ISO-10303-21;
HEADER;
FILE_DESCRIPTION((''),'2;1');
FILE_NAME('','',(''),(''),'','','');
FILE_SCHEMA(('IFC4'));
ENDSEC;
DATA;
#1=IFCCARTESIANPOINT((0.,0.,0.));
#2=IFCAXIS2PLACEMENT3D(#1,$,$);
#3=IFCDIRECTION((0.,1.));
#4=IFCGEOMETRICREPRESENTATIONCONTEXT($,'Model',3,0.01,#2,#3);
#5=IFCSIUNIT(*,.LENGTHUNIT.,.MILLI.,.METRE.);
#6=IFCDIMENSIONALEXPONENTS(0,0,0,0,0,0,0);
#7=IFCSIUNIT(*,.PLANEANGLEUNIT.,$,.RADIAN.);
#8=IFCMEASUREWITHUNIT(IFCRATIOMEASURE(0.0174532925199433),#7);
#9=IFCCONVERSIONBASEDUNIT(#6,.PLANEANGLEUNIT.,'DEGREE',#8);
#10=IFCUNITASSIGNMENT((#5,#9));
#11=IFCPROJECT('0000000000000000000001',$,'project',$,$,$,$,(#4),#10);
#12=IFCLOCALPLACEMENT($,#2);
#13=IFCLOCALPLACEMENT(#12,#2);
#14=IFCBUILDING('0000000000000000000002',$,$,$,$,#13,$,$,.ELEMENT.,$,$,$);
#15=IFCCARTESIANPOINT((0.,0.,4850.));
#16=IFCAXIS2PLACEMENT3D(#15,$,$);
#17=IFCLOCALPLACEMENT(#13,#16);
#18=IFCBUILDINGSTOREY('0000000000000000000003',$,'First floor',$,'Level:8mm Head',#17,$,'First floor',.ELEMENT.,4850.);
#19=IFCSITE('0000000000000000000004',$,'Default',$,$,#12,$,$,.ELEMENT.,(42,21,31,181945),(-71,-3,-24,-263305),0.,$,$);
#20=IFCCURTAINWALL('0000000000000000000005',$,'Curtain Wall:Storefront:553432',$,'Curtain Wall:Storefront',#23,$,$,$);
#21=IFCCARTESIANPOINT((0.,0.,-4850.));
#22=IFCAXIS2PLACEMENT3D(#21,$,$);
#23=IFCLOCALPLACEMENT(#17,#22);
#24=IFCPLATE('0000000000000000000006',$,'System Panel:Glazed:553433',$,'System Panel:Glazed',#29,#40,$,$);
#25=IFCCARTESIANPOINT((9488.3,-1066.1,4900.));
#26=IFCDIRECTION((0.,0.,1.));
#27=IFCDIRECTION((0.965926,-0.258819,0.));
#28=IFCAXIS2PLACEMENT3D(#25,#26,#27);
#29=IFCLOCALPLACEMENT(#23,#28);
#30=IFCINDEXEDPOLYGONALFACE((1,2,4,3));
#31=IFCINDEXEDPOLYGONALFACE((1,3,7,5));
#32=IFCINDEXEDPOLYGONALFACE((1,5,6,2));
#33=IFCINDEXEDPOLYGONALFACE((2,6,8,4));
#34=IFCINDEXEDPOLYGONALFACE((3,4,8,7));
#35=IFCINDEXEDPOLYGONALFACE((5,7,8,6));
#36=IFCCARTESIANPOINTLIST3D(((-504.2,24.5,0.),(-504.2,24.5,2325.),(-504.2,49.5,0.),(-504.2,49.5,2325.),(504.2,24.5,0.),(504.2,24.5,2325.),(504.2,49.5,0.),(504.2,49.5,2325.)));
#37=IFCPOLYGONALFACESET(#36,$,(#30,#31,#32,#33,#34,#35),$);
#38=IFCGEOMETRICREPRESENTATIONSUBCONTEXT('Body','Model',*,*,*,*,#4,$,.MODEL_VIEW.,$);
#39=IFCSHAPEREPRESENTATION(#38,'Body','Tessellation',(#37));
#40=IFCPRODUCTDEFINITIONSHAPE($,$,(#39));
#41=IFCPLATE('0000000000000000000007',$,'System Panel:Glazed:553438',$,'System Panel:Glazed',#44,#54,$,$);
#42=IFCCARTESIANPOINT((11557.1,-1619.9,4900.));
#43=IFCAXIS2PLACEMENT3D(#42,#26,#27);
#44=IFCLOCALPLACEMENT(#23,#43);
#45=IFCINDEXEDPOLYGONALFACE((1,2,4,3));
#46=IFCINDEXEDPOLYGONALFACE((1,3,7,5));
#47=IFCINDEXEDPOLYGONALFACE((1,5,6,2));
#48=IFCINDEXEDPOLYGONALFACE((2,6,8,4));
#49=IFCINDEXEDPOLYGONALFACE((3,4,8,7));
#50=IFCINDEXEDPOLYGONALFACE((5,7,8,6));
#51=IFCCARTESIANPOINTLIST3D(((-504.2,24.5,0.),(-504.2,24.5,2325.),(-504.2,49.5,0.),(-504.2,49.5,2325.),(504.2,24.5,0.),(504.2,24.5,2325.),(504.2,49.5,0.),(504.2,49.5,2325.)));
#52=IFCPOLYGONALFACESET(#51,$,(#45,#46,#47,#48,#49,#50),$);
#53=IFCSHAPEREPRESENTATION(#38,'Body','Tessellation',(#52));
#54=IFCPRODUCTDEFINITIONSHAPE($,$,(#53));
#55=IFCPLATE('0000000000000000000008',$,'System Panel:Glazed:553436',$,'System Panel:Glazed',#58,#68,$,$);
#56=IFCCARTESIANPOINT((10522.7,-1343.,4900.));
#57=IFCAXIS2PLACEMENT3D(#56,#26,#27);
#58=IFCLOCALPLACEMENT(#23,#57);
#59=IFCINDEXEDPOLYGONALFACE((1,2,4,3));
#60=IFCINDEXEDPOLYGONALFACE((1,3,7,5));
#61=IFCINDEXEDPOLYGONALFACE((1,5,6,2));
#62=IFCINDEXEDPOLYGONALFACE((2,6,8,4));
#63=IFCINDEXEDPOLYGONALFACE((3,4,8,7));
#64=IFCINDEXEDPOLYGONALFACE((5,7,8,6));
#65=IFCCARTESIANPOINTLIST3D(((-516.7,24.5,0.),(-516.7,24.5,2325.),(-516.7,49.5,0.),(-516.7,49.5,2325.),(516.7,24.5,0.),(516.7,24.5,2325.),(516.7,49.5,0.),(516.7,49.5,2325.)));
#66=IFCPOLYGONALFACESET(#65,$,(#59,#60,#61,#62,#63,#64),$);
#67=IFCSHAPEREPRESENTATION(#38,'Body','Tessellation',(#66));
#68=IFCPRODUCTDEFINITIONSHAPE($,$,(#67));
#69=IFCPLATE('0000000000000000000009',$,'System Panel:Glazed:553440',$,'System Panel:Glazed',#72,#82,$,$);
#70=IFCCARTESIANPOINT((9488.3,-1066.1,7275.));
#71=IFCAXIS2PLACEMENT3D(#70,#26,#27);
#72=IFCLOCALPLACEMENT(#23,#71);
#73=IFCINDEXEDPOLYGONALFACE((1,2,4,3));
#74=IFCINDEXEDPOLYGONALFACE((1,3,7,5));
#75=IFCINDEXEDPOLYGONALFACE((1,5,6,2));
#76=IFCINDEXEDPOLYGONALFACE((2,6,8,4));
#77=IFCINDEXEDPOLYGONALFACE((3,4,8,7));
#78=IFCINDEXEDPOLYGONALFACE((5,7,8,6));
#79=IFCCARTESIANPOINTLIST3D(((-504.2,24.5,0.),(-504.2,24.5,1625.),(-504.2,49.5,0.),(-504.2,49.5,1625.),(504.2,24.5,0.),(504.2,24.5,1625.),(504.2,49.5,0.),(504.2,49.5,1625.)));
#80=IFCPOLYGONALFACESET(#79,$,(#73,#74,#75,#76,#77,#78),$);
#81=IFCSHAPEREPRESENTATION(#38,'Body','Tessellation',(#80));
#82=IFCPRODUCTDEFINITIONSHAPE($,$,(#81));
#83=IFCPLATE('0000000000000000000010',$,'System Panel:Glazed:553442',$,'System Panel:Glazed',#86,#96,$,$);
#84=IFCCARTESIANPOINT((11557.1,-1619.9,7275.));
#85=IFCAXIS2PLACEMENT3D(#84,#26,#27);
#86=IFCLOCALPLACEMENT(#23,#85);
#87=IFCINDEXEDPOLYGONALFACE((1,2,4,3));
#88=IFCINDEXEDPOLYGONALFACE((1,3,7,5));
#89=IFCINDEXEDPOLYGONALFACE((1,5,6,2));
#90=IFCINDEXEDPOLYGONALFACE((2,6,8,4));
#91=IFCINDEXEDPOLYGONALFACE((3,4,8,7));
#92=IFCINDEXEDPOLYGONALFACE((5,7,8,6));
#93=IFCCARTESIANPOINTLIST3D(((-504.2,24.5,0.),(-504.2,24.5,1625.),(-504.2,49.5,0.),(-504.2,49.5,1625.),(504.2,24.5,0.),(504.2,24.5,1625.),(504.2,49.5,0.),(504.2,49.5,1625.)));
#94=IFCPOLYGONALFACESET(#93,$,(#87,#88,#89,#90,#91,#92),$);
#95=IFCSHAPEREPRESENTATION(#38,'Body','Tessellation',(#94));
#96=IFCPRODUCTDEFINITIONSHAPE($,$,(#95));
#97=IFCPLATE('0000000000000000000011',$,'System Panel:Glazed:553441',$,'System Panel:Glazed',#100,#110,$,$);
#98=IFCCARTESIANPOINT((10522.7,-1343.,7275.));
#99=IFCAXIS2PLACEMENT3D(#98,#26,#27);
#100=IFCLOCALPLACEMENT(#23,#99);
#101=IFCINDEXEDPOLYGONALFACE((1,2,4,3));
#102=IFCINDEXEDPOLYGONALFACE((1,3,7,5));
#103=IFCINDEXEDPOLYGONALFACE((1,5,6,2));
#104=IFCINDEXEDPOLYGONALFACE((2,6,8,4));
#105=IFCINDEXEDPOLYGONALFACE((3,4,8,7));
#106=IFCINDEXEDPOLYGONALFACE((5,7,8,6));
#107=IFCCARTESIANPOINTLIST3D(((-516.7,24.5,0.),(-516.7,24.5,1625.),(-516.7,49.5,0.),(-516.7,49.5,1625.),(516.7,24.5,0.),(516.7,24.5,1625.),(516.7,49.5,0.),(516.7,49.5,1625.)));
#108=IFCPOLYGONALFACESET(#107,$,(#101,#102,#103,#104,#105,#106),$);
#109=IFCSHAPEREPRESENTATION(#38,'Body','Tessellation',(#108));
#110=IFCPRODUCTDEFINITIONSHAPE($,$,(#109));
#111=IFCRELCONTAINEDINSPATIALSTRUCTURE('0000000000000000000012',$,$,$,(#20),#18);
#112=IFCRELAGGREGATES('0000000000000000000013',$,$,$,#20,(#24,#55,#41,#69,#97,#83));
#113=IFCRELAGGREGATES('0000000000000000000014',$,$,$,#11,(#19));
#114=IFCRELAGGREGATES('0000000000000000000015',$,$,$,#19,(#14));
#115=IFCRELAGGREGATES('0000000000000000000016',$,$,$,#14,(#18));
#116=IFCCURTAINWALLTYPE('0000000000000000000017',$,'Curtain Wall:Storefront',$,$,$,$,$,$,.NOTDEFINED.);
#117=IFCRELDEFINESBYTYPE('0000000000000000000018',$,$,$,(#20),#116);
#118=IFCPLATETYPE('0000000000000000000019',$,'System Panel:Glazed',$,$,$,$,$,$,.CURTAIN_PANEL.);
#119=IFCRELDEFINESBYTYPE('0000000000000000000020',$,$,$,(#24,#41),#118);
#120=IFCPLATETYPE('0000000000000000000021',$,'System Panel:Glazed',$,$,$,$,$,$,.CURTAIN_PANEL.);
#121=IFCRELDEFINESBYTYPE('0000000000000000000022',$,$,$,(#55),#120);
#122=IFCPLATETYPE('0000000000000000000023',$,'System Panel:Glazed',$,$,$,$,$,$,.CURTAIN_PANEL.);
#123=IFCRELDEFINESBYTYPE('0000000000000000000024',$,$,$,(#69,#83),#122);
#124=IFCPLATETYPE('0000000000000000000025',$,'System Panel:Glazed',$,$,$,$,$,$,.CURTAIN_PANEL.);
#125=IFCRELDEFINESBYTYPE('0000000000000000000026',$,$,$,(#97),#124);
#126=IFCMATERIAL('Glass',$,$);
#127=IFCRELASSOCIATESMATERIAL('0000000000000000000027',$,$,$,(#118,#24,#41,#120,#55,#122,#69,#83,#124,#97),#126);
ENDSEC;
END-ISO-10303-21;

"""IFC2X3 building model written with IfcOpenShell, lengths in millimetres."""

from ifc_helpers import new_model, entity, si_unit, converted_unit, direction, frame, frame_2d, origin, place, context, subcontext, project, spatial, rectangle, extrude, source, transform, mapped, material, type_object, type_shapes, element, aggregate, save


model = new_model("IFC2X3")

# Units and contexts
model_context = context("Model", 3, precision=0.01, world=origin(), true_north=direction((0.0, 1.0)))
body_context = subcontext(model_context, "Body", "Model", "MODEL_VIEW")
ifc_project = project(units=[si_unit("LENGTHUNIT", "METRE", prefix="MILLI"), converted_unit("PLANEANGLEUNIT", "DEGREE", entity("IfcRatioMeasure", 0.0174532925199433), si_unit("PLANEANGLEUNIT", "RADIAN"), dimensions=[0, 0, 0, 0, 0, 0, 0])], contexts=[model_context])

# Site, building, storey
site_placement = place(None, origin())
site = spatial("IfcSite", under=ifc_project, at=site_placement, Name="Default", CompositionType="ELEMENT", RefLatitude=(42, 21, 31, 181945), RefLongitude=(-71, -3, -24, -263305), RefElevation=0.0)
building_placement = place(site_placement, origin())
building = spatial("IfcBuilding", under=site, at=building_placement, CompositionType="ELEMENT")
storey_placement = place(building_placement, frame((0.0, 0.0, 4850.0)))
storey = spatial("IfcBuildingStorey", under=building, at=storey_placement, Name="First floor", ObjectType="Level:8mm Head", LongName="First floor", CompositionType="ELEMENT", Elevation=4850.0)

# Curtain wall, plates
curtain_wall_type = type_object("IfcCurtainWallType", Name="Curtain Wall:Storefront", PredefinedType="NOTDEFINED")
curtain_wall_placement = place(storey_placement, frame((0.0, 0.0, -4850.0)))
curtain_wall = element("IfcCurtainWall", 1, at=curtain_wall_placement, inside=storey, type_object=curtain_wall_type, Name="Curtain Wall:Storefront:553432", ObjectType="Curtain Wall:Storefront")
ifc_material_1 = material(Name="Glass")
plate_type_1 = type_object("IfcPlateType", Name="System Panel:Glazed", PredefinedType="CURTAIN_PANEL", material=ifc_material_1)
shared_shape_1 = source(origin(), body_context, "Body", "SweptSolid", [
    extrude(rectangle(XDim=25.0, YDim=1008.3, at=frame_2d((0.0, 0.0), x_axis=(1.0, 0.0))), frame((0.0, 37.0, 0.0), z_axis=(0.0, 0.0, 1.0), x_axis=(0.0, 1.0, 0.0)), (0.0, 0.0, 1.0), 2325.0),
])
type_shapes(plate_type_1, [shared_shape_1])
plate_1_placement = place(curtain_wall_placement, frame((9488.3, -1066.1, 4900.0), z_axis=(0.0, 0.0, 1.0), x_axis=(0.965926, -0.258819, 0.0)))
plate_1 = element("IfcPlate", 2, at=plate_1_placement, type_object=plate_type_1, material=ifc_material_1, Name="System Panel:Glazed:553433", ObjectType="System Panel:Glazed", context=body_context, shape_type="MappedRepresentation", body=[
    mapped(shared_shape_1, transform((0.0, 0.0, 0.0), scale=1.0)),
])
plate_2_placement = place(curtain_wall_placement, frame((11557.1, -1619.9, 4900.0), z_axis=(0.0, 0.0, 1.0), x_axis=(0.965926, -0.258819, 0.0)))
plate_2 = element("IfcPlate", 3, at=plate_2_placement, type_object=plate_type_1, material=ifc_material_1, Name="System Panel:Glazed:553438", ObjectType="System Panel:Glazed", context=body_context, shape_type="MappedRepresentation", body=[
    mapped(shared_shape_1, transform((0.0, 0.0, 0.0), scale=1.0)),
])
plate_type_2 = type_object("IfcPlateType", Name="System Panel:Glazed", PredefinedType="CURTAIN_PANEL", material=ifc_material_1)
shared_shape_2 = source(origin(), body_context, "Body", "SweptSolid", [
    extrude(rectangle(XDim=25.0, YDim=1033.3, at=frame_2d((0.0, 0.0), x_axis=(1.0, 0.0))), frame((0.0, 37.0, 0.0), z_axis=(0.0, 0.0, 1.0), x_axis=(0.0, 1.0, 0.0)), (0.0, 0.0, 1.0), 2325.0),
])
type_shapes(plate_type_2, [shared_shape_2])
plate_3_placement = place(curtain_wall_placement, frame((10522.7, -1343.0, 4900.0), z_axis=(0.0, 0.0, 1.0), x_axis=(0.965926, -0.258819, 0.0)))
plate_3 = element("IfcPlate", 4, at=plate_3_placement, type_object=plate_type_2, material=ifc_material_1, Name="System Panel:Glazed:553436", ObjectType="System Panel:Glazed", context=body_context, shape_type="MappedRepresentation", body=[
    mapped(shared_shape_2, transform((0.0, 0.0, 0.0), scale=1.0)),
])
plate_type_3 = type_object("IfcPlateType", Name="System Panel:Glazed", PredefinedType="CURTAIN_PANEL", material=ifc_material_1)
shared_shape_3 = source(origin(), body_context, "Body", "SweptSolid", [
    extrude(rectangle(XDim=25.0, YDim=1008.3, at=frame_2d((0.0, 0.0), x_axis=(1.0, 0.0))), frame((0.0, 37.0, 0.0), z_axis=(0.0, 0.0, 1.0), x_axis=(0.0, 1.0, 0.0)), (0.0, 0.0, 1.0), 1625.0),
])
type_shapes(plate_type_3, [shared_shape_3])
plate_4_placement = place(curtain_wall_placement, frame((9488.3, -1066.1, 7275.0), z_axis=(0.0, 0.0, 1.0), x_axis=(0.965926, -0.258819, 0.0)))
plate_4 = element("IfcPlate", 5, at=plate_4_placement, type_object=plate_type_3, material=ifc_material_1, Name="System Panel:Glazed:553440", ObjectType="System Panel:Glazed", context=body_context, shape_type="MappedRepresentation", body=[
    mapped(shared_shape_3, transform((0.0, 0.0, 0.0), scale=1.0)),
])
plate_5_placement = place(curtain_wall_placement, frame((11557.1, -1619.9, 7275.0), z_axis=(0.0, 0.0, 1.0), x_axis=(0.965926, -0.258819, 0.0)))
plate_5 = element("IfcPlate", 6, at=plate_5_placement, type_object=plate_type_3, material=ifc_material_1, Name="System Panel:Glazed:553442", ObjectType="System Panel:Glazed", context=body_context, shape_type="MappedRepresentation", body=[
    mapped(shared_shape_3, transform((0.0, 0.0, 0.0), scale=1.0)),
])
plate_type_4 = type_object("IfcPlateType", Name="System Panel:Glazed", PredefinedType="CURTAIN_PANEL", material=ifc_material_1)
shared_shape_4 = source(origin(), body_context, "Body", "SweptSolid", [
    extrude(rectangle(XDim=25.0, YDim=1033.3, at=frame_2d((0.0, 0.0), x_axis=(1.0, 0.0))), frame((0.0, 37.0, 0.0), z_axis=(0.0, 0.0, 1.0), x_axis=(0.0, 1.0, 0.0)), (0.0, 0.0, 1.0), 1625.0),
])
type_shapes(plate_type_4, [shared_shape_4])
plate_6_placement = place(curtain_wall_placement, frame((10522.7, -1343.0, 7275.0), z_axis=(0.0, 0.0, 1.0), x_axis=(0.965926, -0.258819, 0.0)))
plate_6 = element("IfcPlate", 7, at=plate_6_placement, type_object=plate_type_4, material=ifc_material_1, Name="System Panel:Glazed:553441", ObjectType="System Panel:Glazed", context=body_context, shape_type="MappedRepresentation", body=[
    mapped(shared_shape_4, transform((0.0, 0.0, 0.0), scale=1.0)),
])
aggregate(curtain_wall, [plate_1, plate_3, plate_2, plate_4, plate_6, plate_5])

save(model, "model.ifc")
